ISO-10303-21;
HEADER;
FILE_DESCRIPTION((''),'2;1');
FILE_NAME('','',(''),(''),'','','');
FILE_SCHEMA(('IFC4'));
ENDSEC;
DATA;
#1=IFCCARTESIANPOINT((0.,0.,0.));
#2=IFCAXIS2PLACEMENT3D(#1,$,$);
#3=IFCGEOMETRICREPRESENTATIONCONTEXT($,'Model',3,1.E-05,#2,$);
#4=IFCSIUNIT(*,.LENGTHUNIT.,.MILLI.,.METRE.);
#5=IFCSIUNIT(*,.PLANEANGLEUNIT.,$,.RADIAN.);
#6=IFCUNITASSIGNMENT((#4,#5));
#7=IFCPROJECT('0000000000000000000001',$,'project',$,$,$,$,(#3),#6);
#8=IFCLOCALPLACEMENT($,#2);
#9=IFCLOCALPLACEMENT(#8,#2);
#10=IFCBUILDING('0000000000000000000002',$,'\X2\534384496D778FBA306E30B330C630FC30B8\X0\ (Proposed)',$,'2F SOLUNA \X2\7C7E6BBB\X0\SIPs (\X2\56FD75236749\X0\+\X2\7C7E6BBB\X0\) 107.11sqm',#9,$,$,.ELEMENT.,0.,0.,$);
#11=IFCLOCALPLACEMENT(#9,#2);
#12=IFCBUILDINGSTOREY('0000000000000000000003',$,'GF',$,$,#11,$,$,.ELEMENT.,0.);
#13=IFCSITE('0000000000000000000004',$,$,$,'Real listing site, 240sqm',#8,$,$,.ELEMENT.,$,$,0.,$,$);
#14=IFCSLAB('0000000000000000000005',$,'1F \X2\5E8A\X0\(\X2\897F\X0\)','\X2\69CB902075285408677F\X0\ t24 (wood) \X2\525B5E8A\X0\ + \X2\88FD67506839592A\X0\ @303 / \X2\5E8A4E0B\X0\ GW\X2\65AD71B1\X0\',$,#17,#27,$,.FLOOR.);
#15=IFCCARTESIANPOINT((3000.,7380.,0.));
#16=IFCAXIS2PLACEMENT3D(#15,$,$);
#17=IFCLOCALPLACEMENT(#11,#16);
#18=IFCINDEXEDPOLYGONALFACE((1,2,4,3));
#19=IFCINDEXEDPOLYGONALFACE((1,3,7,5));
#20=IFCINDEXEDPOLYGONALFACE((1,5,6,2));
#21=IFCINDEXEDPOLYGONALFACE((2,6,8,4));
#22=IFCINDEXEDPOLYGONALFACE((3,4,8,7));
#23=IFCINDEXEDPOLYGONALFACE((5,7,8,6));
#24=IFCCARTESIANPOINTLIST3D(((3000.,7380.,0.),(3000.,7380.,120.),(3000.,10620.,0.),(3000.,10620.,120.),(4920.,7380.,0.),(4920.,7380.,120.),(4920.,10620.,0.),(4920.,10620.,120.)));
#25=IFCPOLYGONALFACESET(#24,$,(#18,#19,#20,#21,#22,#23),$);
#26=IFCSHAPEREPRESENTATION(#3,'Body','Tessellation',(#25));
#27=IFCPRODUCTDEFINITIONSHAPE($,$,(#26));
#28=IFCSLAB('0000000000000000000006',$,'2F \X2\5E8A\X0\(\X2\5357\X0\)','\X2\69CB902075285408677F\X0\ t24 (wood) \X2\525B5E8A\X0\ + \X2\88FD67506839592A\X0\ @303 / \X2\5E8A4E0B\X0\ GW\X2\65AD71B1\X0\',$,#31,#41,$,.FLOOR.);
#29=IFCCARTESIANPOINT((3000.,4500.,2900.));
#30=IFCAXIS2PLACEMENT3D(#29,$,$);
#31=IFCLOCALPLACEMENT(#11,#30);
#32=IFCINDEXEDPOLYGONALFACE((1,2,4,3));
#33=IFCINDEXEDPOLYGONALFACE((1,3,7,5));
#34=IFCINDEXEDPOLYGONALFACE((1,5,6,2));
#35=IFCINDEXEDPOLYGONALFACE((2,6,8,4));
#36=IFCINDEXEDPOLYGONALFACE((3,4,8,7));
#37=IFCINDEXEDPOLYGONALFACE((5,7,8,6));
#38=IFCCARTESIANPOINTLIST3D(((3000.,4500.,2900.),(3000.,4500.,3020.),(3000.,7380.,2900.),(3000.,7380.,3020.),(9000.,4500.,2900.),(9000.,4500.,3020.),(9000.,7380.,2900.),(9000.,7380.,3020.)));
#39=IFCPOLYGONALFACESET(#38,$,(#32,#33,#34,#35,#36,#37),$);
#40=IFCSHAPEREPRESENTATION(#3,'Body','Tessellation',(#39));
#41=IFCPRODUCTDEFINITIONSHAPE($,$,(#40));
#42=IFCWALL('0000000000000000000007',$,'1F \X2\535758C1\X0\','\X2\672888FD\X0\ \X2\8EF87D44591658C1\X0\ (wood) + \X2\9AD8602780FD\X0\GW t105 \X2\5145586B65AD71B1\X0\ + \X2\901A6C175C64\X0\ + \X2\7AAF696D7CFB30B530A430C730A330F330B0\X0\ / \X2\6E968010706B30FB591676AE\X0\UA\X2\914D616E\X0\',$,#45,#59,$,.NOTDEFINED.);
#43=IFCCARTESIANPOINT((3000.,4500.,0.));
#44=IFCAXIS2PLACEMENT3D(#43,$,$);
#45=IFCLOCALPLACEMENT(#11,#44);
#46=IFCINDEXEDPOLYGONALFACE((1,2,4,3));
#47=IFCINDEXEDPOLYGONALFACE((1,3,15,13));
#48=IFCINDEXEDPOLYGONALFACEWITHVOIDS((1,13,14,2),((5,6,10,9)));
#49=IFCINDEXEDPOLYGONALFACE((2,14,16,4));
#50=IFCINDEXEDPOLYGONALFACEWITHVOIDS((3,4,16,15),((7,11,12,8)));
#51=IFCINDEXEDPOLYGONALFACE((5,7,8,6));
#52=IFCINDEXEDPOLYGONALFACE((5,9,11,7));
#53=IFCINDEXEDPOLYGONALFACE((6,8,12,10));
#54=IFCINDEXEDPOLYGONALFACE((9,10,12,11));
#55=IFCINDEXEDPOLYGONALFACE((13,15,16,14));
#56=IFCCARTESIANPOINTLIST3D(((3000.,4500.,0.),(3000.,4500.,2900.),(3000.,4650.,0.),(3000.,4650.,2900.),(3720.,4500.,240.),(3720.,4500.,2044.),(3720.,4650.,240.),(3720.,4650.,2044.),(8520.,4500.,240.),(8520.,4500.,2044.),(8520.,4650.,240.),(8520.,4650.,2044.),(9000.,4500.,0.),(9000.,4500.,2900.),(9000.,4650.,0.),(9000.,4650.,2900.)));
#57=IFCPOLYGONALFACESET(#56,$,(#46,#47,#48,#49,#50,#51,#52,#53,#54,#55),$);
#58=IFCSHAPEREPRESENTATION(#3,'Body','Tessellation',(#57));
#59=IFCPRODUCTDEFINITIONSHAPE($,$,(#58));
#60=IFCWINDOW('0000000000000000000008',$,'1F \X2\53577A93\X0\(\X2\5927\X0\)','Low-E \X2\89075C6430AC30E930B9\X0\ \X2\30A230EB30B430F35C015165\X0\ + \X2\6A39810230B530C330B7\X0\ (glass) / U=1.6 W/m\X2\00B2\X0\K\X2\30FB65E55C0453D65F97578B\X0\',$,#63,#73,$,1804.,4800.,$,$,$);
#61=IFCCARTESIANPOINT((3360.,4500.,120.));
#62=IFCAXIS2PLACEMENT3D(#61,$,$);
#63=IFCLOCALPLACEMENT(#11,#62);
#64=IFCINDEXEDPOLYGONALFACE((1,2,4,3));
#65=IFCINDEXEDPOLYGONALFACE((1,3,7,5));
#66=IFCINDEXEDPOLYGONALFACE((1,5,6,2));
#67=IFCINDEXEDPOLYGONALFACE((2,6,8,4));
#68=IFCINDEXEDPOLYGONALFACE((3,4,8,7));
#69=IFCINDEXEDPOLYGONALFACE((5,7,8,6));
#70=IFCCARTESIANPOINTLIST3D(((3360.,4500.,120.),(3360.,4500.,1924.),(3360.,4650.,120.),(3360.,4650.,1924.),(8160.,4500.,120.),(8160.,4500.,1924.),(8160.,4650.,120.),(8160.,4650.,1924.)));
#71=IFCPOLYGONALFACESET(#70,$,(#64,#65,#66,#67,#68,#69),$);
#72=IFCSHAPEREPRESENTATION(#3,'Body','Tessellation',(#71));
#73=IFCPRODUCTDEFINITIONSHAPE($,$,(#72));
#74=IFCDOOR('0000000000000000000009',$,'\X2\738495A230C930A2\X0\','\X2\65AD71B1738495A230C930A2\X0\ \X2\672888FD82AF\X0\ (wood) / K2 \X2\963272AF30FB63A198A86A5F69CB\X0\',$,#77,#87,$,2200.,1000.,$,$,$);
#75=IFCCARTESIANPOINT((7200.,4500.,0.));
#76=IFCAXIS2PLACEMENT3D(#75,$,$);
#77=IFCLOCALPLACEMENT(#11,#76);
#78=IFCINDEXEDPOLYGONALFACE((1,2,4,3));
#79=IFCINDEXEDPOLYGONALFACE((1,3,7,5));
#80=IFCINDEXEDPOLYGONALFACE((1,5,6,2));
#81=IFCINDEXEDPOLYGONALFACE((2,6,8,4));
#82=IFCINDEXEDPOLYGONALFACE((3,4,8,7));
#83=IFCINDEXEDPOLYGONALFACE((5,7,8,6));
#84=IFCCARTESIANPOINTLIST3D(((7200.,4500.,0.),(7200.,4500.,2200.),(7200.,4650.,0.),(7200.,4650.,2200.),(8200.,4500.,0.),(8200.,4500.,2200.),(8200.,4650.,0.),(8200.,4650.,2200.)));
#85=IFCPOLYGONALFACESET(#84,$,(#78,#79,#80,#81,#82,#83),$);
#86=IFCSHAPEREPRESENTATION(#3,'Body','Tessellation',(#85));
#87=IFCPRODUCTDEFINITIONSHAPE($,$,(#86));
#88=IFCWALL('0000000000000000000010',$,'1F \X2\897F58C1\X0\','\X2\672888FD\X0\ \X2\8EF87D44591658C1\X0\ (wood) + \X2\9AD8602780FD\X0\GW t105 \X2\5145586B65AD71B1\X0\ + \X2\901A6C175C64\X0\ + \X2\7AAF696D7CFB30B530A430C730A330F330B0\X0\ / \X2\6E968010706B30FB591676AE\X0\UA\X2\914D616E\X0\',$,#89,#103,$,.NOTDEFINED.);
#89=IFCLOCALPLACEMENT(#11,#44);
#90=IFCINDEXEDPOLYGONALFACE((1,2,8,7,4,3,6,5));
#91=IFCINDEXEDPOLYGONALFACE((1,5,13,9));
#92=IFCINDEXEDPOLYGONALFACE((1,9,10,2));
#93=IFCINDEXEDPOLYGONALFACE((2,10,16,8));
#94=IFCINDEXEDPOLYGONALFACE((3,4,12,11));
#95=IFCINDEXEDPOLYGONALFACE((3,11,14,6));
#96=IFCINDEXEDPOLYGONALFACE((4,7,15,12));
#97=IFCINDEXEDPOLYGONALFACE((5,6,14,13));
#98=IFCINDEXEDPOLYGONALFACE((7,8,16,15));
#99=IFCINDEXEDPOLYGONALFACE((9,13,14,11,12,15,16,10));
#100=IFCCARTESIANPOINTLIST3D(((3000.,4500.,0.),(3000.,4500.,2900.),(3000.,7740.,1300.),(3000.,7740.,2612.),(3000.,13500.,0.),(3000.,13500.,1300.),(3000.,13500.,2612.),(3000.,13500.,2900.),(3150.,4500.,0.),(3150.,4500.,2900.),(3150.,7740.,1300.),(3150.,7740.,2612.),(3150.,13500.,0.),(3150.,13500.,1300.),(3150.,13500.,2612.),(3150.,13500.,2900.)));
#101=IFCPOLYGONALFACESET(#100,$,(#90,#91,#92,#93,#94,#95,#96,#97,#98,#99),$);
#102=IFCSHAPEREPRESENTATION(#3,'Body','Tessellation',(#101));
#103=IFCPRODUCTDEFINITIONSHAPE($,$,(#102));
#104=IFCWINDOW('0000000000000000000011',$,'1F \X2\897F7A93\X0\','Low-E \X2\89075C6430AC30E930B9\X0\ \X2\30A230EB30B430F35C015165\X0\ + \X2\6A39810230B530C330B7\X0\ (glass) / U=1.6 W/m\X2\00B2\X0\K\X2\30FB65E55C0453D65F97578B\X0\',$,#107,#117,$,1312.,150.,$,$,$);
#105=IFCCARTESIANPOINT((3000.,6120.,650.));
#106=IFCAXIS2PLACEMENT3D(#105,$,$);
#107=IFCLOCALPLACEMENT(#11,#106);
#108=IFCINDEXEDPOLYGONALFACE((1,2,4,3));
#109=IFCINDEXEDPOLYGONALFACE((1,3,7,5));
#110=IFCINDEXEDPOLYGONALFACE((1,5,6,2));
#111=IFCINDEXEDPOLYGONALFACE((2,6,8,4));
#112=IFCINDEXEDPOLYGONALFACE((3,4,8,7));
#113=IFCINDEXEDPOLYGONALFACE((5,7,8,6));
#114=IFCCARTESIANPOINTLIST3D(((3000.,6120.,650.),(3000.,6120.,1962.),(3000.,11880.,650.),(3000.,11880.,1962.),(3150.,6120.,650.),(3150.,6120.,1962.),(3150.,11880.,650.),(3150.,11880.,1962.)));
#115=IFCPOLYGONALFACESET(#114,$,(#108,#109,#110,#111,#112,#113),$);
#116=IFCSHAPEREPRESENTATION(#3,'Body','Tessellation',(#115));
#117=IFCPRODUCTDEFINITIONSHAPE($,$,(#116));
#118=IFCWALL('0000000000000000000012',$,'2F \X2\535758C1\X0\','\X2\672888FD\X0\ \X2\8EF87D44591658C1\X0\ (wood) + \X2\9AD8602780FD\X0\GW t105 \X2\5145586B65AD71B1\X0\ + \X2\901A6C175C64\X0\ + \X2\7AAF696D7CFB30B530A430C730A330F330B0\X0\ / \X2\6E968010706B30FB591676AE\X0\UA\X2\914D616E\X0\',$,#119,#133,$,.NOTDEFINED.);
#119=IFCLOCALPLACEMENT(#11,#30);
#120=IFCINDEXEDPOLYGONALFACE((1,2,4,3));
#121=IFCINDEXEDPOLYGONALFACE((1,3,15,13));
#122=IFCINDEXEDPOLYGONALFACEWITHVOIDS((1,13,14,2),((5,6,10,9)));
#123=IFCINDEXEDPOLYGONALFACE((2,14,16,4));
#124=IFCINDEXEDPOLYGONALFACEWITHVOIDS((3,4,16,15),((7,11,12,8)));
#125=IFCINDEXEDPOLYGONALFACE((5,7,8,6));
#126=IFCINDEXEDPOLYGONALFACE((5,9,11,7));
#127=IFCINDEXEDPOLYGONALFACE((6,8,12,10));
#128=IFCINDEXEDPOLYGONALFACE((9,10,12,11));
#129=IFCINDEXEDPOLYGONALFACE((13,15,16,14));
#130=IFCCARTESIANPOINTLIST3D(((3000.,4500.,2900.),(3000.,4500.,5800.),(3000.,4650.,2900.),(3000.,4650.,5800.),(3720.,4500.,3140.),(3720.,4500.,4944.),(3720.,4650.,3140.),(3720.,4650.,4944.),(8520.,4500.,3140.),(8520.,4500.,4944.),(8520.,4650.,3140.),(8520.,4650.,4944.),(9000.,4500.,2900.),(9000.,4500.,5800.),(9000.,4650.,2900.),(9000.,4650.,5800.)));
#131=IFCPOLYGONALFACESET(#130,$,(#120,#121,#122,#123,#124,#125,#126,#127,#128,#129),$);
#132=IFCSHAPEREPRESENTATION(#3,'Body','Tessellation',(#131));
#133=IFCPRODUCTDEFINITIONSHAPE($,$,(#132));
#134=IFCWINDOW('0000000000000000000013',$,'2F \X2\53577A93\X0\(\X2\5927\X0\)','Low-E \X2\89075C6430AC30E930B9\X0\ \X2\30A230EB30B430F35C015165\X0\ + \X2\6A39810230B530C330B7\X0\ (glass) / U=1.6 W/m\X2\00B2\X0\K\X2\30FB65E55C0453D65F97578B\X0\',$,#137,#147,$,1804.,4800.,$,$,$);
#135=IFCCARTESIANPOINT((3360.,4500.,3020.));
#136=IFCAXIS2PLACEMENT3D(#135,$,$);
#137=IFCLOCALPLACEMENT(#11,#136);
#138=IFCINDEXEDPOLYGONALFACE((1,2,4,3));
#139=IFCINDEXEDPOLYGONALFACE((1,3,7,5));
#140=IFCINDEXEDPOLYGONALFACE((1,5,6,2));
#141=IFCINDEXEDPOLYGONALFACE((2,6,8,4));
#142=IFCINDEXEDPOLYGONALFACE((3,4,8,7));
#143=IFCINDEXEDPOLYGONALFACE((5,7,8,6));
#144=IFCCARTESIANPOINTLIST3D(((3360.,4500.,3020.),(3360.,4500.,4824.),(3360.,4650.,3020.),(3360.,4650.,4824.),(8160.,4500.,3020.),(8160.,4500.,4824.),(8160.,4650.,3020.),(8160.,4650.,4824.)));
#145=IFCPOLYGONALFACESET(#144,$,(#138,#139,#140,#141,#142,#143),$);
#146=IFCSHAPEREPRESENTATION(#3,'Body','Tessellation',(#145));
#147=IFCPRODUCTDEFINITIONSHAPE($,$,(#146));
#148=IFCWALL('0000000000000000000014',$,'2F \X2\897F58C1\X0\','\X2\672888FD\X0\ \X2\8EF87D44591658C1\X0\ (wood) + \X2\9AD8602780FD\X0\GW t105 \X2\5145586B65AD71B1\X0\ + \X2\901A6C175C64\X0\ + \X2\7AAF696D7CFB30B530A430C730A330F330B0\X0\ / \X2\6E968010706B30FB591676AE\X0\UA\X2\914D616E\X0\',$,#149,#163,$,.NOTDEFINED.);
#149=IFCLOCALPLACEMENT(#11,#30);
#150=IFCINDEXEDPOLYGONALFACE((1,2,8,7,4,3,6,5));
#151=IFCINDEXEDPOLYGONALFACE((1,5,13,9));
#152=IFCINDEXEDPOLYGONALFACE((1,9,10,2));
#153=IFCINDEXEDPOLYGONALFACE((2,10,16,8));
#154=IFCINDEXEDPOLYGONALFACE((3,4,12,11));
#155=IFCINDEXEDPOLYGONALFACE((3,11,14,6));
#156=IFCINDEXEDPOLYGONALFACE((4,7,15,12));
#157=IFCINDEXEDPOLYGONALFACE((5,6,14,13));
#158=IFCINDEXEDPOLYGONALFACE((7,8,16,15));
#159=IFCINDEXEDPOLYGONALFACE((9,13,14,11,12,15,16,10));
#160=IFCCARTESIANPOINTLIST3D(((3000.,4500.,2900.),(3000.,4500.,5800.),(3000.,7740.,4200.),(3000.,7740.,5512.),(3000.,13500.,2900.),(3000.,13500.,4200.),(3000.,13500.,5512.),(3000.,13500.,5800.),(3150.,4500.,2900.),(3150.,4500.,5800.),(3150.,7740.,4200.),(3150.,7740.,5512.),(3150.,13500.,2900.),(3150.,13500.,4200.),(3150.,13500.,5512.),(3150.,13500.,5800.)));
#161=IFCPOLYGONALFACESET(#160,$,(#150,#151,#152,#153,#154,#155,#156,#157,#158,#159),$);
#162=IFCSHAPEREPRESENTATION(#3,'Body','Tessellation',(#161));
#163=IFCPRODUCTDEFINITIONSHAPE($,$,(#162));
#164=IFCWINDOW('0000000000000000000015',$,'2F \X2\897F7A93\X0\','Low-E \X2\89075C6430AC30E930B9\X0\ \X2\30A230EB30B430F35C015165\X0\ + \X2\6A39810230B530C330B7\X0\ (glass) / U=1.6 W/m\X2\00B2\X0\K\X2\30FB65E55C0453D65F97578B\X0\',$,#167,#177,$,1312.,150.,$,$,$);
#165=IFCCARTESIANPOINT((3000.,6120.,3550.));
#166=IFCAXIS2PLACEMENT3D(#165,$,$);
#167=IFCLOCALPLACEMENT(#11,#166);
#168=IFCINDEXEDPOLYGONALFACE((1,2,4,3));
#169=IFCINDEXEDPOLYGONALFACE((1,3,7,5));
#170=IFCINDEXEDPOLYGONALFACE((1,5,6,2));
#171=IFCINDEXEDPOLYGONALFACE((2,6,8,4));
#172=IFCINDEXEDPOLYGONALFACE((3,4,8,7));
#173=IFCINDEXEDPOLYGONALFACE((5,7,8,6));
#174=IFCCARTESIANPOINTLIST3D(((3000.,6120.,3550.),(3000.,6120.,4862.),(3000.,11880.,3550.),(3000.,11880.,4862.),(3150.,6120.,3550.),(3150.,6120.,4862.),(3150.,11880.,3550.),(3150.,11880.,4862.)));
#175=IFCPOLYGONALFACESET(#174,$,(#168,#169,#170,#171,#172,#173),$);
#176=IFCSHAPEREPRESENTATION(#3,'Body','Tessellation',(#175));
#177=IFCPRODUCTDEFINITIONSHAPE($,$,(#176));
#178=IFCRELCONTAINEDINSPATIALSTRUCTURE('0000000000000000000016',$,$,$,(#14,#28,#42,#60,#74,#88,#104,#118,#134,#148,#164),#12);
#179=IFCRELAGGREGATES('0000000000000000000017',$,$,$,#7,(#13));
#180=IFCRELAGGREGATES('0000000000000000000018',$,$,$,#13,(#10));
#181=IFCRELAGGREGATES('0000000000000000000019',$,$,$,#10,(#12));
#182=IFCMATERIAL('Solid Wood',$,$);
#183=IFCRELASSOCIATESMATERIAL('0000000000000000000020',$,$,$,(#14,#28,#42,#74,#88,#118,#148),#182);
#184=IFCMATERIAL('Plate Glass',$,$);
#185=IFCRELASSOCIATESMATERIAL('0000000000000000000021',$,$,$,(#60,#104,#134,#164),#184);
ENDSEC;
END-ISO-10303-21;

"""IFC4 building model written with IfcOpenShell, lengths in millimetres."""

from ifc_helpers import new_model, si_unit, frame, frame_2d, origin, place, context, project, spatial, rectangle, extrude, material, element, fill, save


model = new_model("IFC4")

# Units and contexts
model_context = context("Model", 3, precision=1e-05, world=origin())
ifc_project = project(units=[si_unit("LENGTHUNIT", "METRE", prefix="MILLI"), si_unit("PLANEANGLEUNIT", "RADIAN")], contexts=[model_context])

# Site, building, storey
site_placement = place(None, origin())
site = spatial("IfcSite", under=ifc_project, at=site_placement, ObjectType="Real listing site, 240sqm", CompositionType="ELEMENT", RefElevation=0.0)
building_placement = place(site_placement, origin())
building = spatial("IfcBuilding", under=site, at=building_placement, Name="千葉海辺のコテージ (Proposed)", ObjectType="2F SOLUNA 籾殻SIPs (国産杉+籾殻) 107.11sqm", CompositionType="ELEMENT", ElevationOfRefHeight=0.0, ElevationOfTerrain=0.0)
storey_placement = place(building_placement, origin())
storey = spatial("IfcBuildingStorey", under=building, at=storey_placement, Name="GF", CompositionType="ELEMENT", Elevation=0.0)

# Slabs
ifc_material_1 = material(Name="Solid Wood")
slab_1_placement = place(storey_placement, frame((3000.0, 7380.0, 0.0)))
element("IfcSlab", 1, at=slab_1_placement, inside=storey, material=ifc_material_1, Name="1F 床(西)", Description="構造用合板 t24 (wood) 剛床 + 製材根太 @303 / 床下 GW断熱", PredefinedType="FLOOR", context=model_context, shape_type="SweptSolid", body=[
    extrude(rectangle(XDim=1920.0, YDim=3240.0, at=frame_2d((960.0, 1620.0))), frame((3000.0, 7380.0, 0.0)), (0.0, 0.0, 1.0), 120.0),
])
slab_2_placement = place(storey_placement, frame((3000.0, 4500.0, 2900.0)))
element("IfcSlab", 2, at=slab_2_placement, inside=storey, material=ifc_material_1, Name="2F 床(南)", Description="構造用合板 t24 (wood) 剛床 + 製材根太 @303 / 床下 GW断熱", PredefinedType="FLOOR", context=model_context, shape_type="SweptSolid", body=[
    extrude(rectangle(XDim=6000.0, YDim=2880.0, at=frame_2d((3000.0, 1440.0))), frame((3000.0, 4500.0, 2900.0)), (0.0, 0.0, 1.0), 120.0),
])

# Wall, openings, window, door
wall_1_placement = place(storey_placement, frame((3000.0, 4500.0, 0.0)))
wall_1 = element("IfcWall", 3, at=wall_1_placement, inside=storey, material=ifc_material_1, Name="1F 南壁", Description="木製 軸組外壁 (wood) + 高性能GW t105 充填断熱 + 通気層 + 窯業系サイディング / 準耐火・外皮UA配慮", PredefinedType="NOTDEFINED", context=model_context, shape_type="SweptSolid", body=[
    extrude(rectangle(XDim=6000.0, YDim=150.0, at=frame_2d((3000.0, 75.0))), frame((3000.0, 4500.0, 0.0)), (0.0, 0.0, 1.0), 2900.0),
])
opening_1_placement = place(storey_placement, frame((3360.0, 4500.0, 120.0)))
opening_1 = element("IfcOpeningElement", 4, at=opening_1_placement, cuts=wall_1, PredefinedType="NOTDEFINED", context=model_context, shape_type="SweptSolid", body=[
    extrude(rectangle(XDim=4800.0, YDim=150.0, at=frame_2d((2400.0, 75.0))), frame((3360.0, 4500.0, 120.0)), (0.0, 0.0, 1.0), 1804.0),
])
opening_2_placement = place(storey_placement, frame((7200.0, 4500.0, 0.0)))
opening_2 = element("IfcOpeningElement", 5, at=opening_2_placement, cuts=wall_1, PredefinedType="NOTDEFINED", context=model_context, shape_type="SweptSolid", body=[
    extrude(rectangle(XDim=1000.0, YDim=150.0, at=frame_2d((500.0, 75.0))), frame((7200.0, 4500.0, 0.0)), (0.0, 0.0, 1.0), 2200.0),
])
ifc_material_2 = material(Name="Plate Glass")
window_1_placement = place(storey_placement, frame((3360.0, 4500.0, 120.0)))
window_1 = element("IfcWindow", 6, at=window_1_placement, inside=storey, material=ifc_material_2, Name="1F 南窓(大)", Description="Low-E 複層ガラス アルゴン封入 + 樹脂サッシ (glass) / U=1.6 W/m²K・日射取得型", OverallHeight=1804.0, OverallWidth=4800.0, context=model_context, shape_type="SweptSolid", body=[
    extrude(rectangle(XDim=4800.0, YDim=150.0, at=frame_2d((2400.0, 75.0))), frame((3360.0, 4500.0, 120.0)), (0.0, 0.0, 1.0), 1804.0),
])
fill(opening_1, window_1)
door_placement = place(storey_placement, frame((7200.0, 4500.0, 0.0)))
door = element("IfcDoor", 7, at=door_placement, inside=storey, material=ifc_material_1, Name="玄関ドア", Description="断熱玄関ドア 木製芯 (wood) / K2 防犯・採風機構", OverallHeight=2200.0, OverallWidth=1000.0, context=model_context, shape_type="SweptSolid", body=[
    extrude(rectangle(XDim=1000.0, YDim=150.0, at=frame_2d((500.0, 75.0))), frame((7200.0, 4500.0, 0.0)), (0.0, 0.0, 1.0), 2200.0),
])
fill(opening_2, door)

# Walls, openings, windows
wall_2_placement = place(storey_placement, frame((3000.0, 4500.0, 0.0)))
wall_2 = element("IfcWall", 8, at=wall_2_placement, inside=storey, material=ifc_material_1, Name="1F 西壁", Description="木製 軸組外壁 (wood) + 高性能GW t105 充填断熱 + 通気層 + 窯業系サイディング / 準耐火・外皮UA配慮", PredefinedType="NOTDEFINED", context=model_context, shape_type="SweptSolid", body=[
    extrude(rectangle(XDim=150.0, YDim=9000.0, at=frame_2d((75.0, 4500.0))), frame((3000.0, 4500.0, 0.0)), (0.0, 0.0, 1.0), 2900.0),
])
opening_3_placement = place(storey_placement, frame((3000.0, 6120.0, 650.0)))
opening_3 = element("IfcOpeningElement", 9, at=opening_3_placement, cuts=wall_2, PredefinedType="NOTDEFINED", context=model_context, shape_type="SweptSolid", body=[
    extrude(rectangle(XDim=150.0, YDim=5760.0, at=frame_2d((75.0, 2880.0))), frame((3000.0, 6120.0, 650.0)), (0.0, 0.0, 1.0), 1312.0),
])
window_2_placement = place(storey_placement, frame((3000.0, 6120.0, 650.0)))
window_2 = element("IfcWindow", 10, at=window_2_placement, inside=storey, material=ifc_material_2, Name="1F 西窓", Description="Low-E 複層ガラス アルゴン封入 + 樹脂サッシ (glass) / U=1.6 W/m²K・日射取得型", OverallHeight=1312.0, OverallWidth=150.0, context=model_context, shape_type="SweptSolid", body=[
    extrude(rectangle(XDim=150.0, YDim=5760.0, at=frame_2d((75.0, 2880.0))), frame((3000.0, 6120.0, 650.0)), (0.0, 0.0, 1.0), 1312.0),
])
fill(opening_3, window_2)
wall_3_placement = place(storey_placement, frame((3000.0, 4500.0, 2900.0)))
wall_3 = element("IfcWall", 11, at=wall_3_placement, inside=storey, material=ifc_material_1, Name="2F 南壁", Description="木製 軸組外壁 (wood) + 高性能GW t105 充填断熱 + 通気層 + 窯業系サイディング / 準耐火・外皮UA配慮", PredefinedType="NOTDEFINED", context=model_context, shape_type="SweptSolid", body=[
    extrude(rectangle(XDim=6000.0, YDim=150.0, at=frame_2d((3000.0, 75.0))), frame((3000.0, 4500.0, 2900.0)), (0.0, 0.0, 1.0), 2900.0),
])
opening_4_placement = place(storey_placement, frame((3360.0, 4500.0, 3020.0)))
opening_4 = element("IfcOpeningElement", 12, at=opening_4_placement, cuts=wall_3, PredefinedType="NOTDEFINED", context=model_context, shape_type="SweptSolid", body=[
    extrude(rectangle(XDim=4800.0, YDim=150.0, at=frame_2d((2400.0, 75.0))), frame((3360.0, 4500.0, 3020.0)), (0.0, 0.0, 1.0), 1804.0),
])
window_3_placement = place(storey_placement, frame((3360.0, 4500.0, 3020.0)))
window_3 = element("IfcWindow", 13, at=window_3_placement, inside=storey, material=ifc_material_2, Name="2F 南窓(大)", Description="Low-E 複層ガラス アルゴン封入 + 樹脂サッシ (glass) / U=1.6 W/m²K・日射取得型", OverallHeight=1804.0, OverallWidth=4800.0, context=model_context, shape_type="SweptSolid", body=[
    extrude(rectangle(XDim=4800.0, YDim=150.0, at=frame_2d((2400.0, 75.0))), frame((3360.0, 4500.0, 3020.0)), (0.0, 0.0, 1.0), 1804.0),
])
fill(opening_4, window_3)
wall_4_placement = place(storey_placement, frame((3000.0, 4500.0, 2900.0)))
wall_4 = element("IfcWall", 14, at=wall_4_placement, inside=storey, material=ifc_material_1, Name="2F 西壁", Description="木製 軸組外壁 (wood) + 高性能GW t105 充填断熱 + 通気層 + 窯業系サイディング / 準耐火・外皮UA配慮", PredefinedType="NOTDEFINED", context=model_context, shape_type="SweptSolid", body=[
    extrude(rectangle(XDim=150.0, YDim=9000.0, at=frame_2d((75.0, 4500.0))), frame((3000.0, 4500.0, 2900.0)), (0.0, 0.0, 1.0), 2900.0),
])
opening_5_placement = place(storey_placement, frame((3000.0, 6120.0, 3550.0)))
opening_5 = element("IfcOpeningElement", 15, at=opening_5_placement, cuts=wall_4, PredefinedType="NOTDEFINED", context=model_context, shape_type="SweptSolid", body=[
    extrude(rectangle(XDim=150.0, YDim=5760.0, at=frame_2d((75.0, 2880.0))), frame((3000.0, 6120.0, 3550.0)), (0.0, 0.0, 1.0), 1312.0),
])
window_4_placement = place(storey_placement, frame((3000.0, 6120.0, 3550.0)))
window_4 = element("IfcWindow", 16, at=window_4_placement, inside=storey, material=ifc_material_2, Name="2F 西窓", Description="Low-E 複層ガラス アルゴン封入 + 樹脂サッシ (glass) / U=1.6 W/m²K・日射取得型", OverallHeight=1312.0, OverallWidth=150.0, context=model_context, shape_type="SweptSolid", body=[
    extrude(rectangle(XDim=150.0, YDim=5760.0, at=frame_2d((75.0, 2880.0))), frame((3000.0, 6120.0, 3550.0)), (0.0, 0.0, 1.0), 1312.0),
])
fill(opening_5, window_4)

save(model, "model.ifc")
